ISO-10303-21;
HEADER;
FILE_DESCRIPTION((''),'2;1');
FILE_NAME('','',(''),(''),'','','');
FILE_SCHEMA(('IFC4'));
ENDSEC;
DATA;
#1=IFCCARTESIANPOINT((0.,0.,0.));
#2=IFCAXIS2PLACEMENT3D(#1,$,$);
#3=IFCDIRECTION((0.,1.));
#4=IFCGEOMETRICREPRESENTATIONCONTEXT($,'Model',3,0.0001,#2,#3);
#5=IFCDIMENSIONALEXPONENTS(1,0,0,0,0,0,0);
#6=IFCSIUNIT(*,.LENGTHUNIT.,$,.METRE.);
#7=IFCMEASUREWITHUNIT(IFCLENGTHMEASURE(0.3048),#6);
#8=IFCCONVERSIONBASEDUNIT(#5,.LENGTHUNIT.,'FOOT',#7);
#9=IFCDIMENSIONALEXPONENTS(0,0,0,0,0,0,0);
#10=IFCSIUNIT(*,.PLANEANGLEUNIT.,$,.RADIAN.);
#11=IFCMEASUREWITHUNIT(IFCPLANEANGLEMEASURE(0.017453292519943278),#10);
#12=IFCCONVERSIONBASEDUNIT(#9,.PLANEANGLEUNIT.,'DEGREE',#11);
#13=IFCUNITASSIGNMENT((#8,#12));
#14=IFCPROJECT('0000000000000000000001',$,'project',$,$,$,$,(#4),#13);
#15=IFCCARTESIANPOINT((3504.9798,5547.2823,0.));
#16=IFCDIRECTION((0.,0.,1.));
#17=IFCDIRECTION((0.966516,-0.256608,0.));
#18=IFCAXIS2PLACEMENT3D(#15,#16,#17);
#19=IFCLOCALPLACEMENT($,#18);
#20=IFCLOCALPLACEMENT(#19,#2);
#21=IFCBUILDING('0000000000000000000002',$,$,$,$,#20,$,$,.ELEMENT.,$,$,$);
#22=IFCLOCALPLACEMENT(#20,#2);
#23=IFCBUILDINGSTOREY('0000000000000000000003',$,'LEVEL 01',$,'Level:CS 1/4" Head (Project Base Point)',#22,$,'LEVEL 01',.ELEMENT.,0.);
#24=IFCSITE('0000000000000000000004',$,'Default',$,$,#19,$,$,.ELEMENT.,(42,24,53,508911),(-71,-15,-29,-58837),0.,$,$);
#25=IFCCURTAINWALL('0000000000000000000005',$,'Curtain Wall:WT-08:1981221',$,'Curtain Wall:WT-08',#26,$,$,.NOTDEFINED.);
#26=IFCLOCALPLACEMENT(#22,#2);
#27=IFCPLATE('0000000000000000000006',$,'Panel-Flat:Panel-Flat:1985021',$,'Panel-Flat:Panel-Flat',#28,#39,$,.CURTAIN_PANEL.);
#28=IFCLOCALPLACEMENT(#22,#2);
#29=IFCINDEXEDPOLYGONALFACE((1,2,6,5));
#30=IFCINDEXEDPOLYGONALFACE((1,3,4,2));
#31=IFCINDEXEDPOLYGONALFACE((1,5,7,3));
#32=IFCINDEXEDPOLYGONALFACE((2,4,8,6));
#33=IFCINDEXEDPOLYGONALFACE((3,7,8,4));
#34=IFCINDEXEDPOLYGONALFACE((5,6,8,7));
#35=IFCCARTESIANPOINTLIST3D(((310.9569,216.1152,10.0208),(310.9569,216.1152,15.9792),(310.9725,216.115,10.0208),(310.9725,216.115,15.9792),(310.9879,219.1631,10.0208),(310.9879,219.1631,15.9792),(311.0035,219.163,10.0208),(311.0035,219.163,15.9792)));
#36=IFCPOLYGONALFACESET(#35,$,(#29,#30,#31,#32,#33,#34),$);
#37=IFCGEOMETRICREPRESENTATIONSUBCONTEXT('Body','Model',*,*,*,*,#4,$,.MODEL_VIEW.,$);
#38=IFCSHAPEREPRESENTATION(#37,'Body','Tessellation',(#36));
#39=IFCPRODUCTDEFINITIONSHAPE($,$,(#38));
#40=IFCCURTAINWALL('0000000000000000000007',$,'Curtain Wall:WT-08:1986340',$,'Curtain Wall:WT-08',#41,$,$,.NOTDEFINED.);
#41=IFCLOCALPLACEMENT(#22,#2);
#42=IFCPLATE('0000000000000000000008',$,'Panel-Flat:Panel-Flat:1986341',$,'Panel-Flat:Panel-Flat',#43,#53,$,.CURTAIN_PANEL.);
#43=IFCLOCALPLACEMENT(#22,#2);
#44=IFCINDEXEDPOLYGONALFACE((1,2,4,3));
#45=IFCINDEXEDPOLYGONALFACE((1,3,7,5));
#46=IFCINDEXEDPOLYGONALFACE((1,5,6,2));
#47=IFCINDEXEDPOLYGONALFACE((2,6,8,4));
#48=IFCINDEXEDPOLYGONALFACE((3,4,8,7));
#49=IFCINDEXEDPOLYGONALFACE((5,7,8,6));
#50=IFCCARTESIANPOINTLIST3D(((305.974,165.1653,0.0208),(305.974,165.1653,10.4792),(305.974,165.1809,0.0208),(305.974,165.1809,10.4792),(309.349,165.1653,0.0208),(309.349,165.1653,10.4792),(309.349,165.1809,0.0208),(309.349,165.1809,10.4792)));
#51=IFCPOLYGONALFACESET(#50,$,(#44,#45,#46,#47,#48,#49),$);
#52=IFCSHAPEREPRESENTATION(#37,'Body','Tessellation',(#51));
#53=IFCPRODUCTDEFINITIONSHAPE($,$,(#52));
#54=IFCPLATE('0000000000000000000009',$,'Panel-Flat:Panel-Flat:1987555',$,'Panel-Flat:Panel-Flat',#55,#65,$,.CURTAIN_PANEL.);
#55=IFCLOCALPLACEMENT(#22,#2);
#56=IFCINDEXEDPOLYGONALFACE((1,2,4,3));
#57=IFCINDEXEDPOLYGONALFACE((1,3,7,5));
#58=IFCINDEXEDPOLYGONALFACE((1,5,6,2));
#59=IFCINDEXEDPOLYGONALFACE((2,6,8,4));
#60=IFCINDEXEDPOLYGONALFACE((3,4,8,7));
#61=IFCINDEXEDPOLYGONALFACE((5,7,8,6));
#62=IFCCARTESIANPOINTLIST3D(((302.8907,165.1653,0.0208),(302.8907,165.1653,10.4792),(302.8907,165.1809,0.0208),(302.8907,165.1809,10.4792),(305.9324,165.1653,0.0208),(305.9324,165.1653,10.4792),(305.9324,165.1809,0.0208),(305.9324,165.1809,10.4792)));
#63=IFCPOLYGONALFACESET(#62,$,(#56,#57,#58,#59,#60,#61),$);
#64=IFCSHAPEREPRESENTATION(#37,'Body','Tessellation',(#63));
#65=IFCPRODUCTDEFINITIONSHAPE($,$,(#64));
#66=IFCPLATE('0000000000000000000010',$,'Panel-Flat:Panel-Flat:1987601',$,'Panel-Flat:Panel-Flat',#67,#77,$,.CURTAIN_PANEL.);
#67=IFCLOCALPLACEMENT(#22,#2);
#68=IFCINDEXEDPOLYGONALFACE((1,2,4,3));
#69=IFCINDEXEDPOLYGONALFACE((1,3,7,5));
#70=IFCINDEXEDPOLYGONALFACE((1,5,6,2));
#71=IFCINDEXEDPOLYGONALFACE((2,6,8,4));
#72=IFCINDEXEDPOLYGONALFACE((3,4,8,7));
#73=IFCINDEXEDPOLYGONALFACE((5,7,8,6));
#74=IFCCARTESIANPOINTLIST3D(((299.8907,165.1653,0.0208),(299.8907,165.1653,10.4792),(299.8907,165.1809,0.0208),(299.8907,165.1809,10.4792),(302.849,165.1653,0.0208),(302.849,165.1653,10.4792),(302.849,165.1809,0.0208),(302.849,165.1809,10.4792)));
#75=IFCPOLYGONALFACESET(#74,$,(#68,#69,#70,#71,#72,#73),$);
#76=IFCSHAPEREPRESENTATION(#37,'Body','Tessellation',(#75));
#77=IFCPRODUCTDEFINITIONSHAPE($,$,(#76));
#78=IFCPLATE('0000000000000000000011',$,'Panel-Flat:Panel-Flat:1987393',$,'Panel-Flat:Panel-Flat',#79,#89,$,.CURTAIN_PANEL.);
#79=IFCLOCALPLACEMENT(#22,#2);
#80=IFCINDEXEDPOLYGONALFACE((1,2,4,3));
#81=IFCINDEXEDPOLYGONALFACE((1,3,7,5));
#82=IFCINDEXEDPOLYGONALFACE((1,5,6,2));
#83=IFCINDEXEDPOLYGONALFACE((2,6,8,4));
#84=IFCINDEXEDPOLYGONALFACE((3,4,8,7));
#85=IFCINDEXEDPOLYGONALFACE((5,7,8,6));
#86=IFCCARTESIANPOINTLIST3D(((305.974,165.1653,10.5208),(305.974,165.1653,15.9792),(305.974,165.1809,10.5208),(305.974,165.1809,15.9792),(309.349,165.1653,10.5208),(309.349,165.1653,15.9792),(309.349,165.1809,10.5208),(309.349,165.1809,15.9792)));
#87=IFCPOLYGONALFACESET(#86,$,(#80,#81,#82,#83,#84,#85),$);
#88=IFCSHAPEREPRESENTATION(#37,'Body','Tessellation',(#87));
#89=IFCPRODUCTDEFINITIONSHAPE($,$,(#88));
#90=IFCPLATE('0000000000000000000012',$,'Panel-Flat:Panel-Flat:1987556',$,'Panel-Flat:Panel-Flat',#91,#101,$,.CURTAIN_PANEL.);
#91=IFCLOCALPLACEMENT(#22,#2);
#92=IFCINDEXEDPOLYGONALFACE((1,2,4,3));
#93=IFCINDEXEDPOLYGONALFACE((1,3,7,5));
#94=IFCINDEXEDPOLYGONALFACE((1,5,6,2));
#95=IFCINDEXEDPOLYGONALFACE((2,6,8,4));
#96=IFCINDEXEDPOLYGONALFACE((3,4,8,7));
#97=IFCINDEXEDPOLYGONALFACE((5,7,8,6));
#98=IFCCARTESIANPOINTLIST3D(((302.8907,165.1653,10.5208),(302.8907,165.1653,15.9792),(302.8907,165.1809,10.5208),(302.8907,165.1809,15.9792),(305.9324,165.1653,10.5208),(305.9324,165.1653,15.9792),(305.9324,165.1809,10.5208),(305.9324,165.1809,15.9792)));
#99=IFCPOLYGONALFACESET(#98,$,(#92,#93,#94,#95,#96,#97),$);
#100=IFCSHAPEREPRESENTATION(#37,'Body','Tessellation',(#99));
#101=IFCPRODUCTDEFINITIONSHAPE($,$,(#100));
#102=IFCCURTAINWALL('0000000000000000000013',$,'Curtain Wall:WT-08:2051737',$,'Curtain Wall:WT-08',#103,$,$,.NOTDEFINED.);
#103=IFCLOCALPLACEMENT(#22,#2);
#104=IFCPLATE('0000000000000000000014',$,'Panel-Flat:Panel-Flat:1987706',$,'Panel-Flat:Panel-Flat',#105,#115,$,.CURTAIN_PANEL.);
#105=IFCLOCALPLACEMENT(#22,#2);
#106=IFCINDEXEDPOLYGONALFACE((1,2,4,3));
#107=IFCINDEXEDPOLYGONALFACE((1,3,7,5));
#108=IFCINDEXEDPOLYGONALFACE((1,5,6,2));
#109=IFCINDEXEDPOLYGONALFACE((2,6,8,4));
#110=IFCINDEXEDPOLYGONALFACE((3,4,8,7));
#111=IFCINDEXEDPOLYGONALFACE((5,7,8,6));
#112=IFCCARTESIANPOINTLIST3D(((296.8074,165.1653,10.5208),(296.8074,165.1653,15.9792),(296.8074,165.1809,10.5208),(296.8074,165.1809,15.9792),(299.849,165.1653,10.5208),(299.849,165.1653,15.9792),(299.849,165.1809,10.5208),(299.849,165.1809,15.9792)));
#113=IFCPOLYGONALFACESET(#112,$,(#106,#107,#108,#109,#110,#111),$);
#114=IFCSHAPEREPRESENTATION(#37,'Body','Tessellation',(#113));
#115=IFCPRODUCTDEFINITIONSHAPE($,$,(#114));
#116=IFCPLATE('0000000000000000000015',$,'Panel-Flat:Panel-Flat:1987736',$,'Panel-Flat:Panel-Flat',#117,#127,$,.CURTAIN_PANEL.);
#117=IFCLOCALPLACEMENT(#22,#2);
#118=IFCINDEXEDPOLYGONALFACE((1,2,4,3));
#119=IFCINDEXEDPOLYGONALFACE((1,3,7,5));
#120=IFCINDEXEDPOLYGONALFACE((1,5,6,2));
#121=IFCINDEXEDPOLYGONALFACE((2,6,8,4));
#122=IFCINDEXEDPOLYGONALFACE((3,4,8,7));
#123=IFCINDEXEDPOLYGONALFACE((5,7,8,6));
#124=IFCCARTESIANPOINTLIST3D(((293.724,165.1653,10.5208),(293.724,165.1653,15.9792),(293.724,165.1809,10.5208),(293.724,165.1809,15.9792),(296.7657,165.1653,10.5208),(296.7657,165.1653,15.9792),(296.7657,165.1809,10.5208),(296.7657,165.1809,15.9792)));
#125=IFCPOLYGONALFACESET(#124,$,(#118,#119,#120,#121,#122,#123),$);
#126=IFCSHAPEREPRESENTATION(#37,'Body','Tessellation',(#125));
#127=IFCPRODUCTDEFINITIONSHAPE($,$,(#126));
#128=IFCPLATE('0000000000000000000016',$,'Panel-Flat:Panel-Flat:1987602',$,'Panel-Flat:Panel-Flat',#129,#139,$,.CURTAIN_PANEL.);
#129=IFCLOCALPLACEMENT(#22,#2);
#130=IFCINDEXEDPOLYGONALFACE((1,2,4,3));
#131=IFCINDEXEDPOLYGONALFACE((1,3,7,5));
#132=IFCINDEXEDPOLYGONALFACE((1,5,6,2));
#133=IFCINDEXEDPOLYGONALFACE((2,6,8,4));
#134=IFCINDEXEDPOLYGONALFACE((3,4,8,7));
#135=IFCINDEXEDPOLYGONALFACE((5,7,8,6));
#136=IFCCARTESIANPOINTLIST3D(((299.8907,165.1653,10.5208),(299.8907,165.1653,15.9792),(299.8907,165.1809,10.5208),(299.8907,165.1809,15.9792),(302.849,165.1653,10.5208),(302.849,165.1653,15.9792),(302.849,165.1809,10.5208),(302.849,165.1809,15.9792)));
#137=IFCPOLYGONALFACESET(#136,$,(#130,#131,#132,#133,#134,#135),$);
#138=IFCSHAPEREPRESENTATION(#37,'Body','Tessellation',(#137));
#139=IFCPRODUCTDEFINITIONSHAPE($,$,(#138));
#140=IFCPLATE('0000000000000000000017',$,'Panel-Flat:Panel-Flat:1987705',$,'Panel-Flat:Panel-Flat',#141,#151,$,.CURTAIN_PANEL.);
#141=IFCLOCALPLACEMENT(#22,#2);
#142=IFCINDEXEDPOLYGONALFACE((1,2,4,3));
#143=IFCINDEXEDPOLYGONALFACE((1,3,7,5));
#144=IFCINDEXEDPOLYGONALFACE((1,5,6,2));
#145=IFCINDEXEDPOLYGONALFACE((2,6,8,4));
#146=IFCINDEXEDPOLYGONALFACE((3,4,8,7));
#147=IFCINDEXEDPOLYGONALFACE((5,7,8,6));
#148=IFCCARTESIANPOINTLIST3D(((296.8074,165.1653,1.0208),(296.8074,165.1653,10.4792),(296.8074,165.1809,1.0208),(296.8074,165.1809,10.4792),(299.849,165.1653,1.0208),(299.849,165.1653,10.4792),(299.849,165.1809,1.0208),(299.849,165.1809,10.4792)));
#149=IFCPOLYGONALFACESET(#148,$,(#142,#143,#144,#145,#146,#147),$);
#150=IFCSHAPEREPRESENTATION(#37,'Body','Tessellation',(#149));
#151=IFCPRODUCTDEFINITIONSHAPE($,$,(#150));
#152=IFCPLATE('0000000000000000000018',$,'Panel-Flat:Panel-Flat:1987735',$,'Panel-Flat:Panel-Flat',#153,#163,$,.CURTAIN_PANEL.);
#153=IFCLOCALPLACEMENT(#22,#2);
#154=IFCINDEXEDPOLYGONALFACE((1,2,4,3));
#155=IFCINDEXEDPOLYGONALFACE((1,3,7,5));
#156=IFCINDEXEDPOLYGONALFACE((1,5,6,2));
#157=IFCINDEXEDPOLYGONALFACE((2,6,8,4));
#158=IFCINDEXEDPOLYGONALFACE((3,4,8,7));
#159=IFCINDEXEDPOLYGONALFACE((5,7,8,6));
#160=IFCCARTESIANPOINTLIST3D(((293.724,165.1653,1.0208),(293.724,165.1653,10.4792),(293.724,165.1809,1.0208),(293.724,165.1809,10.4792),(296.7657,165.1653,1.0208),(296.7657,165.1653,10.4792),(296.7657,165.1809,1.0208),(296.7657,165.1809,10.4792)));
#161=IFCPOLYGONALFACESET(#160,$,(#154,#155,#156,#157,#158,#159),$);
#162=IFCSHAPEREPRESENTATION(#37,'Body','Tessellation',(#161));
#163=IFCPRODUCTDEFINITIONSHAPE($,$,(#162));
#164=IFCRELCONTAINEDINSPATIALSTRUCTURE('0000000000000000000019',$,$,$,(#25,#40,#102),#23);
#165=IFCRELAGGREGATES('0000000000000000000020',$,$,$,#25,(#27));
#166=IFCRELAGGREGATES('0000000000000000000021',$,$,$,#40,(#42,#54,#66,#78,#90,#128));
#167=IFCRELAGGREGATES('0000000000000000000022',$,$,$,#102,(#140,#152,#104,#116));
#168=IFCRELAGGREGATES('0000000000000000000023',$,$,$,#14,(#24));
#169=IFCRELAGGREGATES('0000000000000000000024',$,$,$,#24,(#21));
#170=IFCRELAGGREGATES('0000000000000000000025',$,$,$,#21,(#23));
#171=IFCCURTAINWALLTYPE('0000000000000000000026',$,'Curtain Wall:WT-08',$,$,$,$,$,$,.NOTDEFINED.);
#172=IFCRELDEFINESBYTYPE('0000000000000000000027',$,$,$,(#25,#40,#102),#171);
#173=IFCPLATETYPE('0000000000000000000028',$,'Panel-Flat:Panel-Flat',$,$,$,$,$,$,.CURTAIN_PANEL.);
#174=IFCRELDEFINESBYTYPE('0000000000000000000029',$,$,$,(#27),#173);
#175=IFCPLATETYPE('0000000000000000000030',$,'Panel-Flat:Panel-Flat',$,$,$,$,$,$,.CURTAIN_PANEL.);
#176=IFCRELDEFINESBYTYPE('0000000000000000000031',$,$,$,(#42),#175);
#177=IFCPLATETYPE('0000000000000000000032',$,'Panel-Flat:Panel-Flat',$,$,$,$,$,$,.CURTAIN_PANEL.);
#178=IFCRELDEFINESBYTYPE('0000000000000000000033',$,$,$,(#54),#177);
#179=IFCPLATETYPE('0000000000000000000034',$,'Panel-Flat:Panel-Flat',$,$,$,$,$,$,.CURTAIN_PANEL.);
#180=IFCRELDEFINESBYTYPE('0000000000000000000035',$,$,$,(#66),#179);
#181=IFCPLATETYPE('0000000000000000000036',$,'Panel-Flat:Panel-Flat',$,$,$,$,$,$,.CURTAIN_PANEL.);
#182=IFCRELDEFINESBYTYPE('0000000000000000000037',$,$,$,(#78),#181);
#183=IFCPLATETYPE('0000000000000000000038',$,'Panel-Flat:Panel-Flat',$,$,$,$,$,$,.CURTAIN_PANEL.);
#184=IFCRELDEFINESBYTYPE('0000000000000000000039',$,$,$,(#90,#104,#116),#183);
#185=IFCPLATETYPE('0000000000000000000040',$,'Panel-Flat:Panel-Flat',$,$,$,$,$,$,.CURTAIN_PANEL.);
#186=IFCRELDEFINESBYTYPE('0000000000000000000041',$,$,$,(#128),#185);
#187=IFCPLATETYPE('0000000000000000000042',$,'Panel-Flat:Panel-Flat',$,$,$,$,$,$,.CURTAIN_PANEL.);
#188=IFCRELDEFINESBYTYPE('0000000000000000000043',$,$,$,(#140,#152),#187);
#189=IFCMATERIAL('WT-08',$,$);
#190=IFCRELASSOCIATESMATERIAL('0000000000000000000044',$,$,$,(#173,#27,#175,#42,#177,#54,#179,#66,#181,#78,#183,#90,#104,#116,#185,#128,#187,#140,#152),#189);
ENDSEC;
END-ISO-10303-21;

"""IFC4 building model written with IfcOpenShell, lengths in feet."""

from ifc_helpers import new_model, entity, si_unit, converted_unit, direction, frame, origin, place, context, subcontext, project, spatial, indexed_curve, outline, extrude, source, transform, mapped, material, type_object, type_shapes, element, aggregate, save


model = new_model("IFC4")

# Units and contexts
model_context = context("Model", 3, precision=0.0001, world=origin(), true_north=direction((0.0, 1.0)))
body_context = subcontext(model_context, "Body", "Model", "MODEL_VIEW")
ifc_project = project(units=[converted_unit("LENGTHUNIT", "FOOT", entity("IfcLengthMeasure", 0.3048), si_unit("LENGTHUNIT", "METRE"), dimensions=[1, 0, 0, 0, 0, 0, 0]), converted_unit("PLANEANGLEUNIT", "DEGREE", entity("IfcPlaneAngleMeasure", 0.017453292519943278), si_unit("PLANEANGLEUNIT", "RADIAN"), dimensions=[0, 0, 0, 0, 0, 0, 0])], contexts=[model_context])

# Site, building, storey
site_placement = place(None, frame((3504.9798, 5547.2823, 0.0), z_axis=(0.0, 0.0, 1.0), x_axis=(0.966516, -0.256608, 0.0)))
site = spatial("IfcSite", under=ifc_project, at=site_placement, Name="Default", CompositionType="ELEMENT", RefLatitude=(42, 24, 53, 508911), RefLongitude=(-71, -15, -29, -58837), RefElevation=0.0)
building_placement = place(site_placement, origin())
building = spatial("IfcBuilding", under=site, at=building_placement, CompositionType="ELEMENT")
storey_placement = place(building_placement, origin())
storey = spatial("IfcBuildingStorey", under=building, at=storey_placement, Name="LEVEL 01", ObjectType="Level:CS 1/4\" Head (Project Base Point)", LongName="LEVEL 01", CompositionType="ELEMENT", Elevation=0.0)

# Curtain walls, plates
curtain_wall_type_1 = type_object("IfcCurtainWallType", Name="Curtain Wall:WT-08", PredefinedType="NOTDEFINED")
curtain_wall_1_placement = place(storey_placement, origin())
curtain_wall_1 = element("IfcCurtainWall", 1, at=curtain_wall_1_placement, inside=storey, type_object=curtain_wall_type_1, Name="Curtain Wall:WT-08:1981221", ObjectType="Curtain Wall:WT-08", PredefinedType="NOTDEFINED")
ifc_material_1 = material(Name="WT-08")
plate_type_1 = type_object("IfcPlateType", Name="Panel-Flat:Panel-Flat", PredefinedType="CURTAIN_PANEL", material=ifc_material_1)
shared_shape_1 = source(origin(), body_context, "Body", "SweptSolid", [
    extrude(outline(indexed_curve([(-0.0078, -1.5241), (0.0078, -1.5241), (0.0078, 1.5241), (-0.0078, 1.5241), (-0.0078, -1.5241)], self_intersect=False)), frame((0.0, -0.0078, 0.0208), z_axis=(0.0, 0.0, 1.0), x_axis=(0.0, -1.0, 0.0)), (0.0, 0.0, 1.0), 5.9583),
])
type_shapes(plate_type_1, [shared_shape_1])
plate_1_placement = place(curtain_wall_1_placement, frame((310.988, 217.639, 10.0), z_axis=(0.0, 0.0, 1.0), x_axis=(-0.010193, -0.999948, 0.0)))
plate_1 = element("IfcPlate", 2, at=plate_1_placement, type_object=plate_type_1, material=ifc_material_1, Name="Panel-Flat:Panel-Flat:1985021", ObjectType="Panel-Flat:Panel-Flat", PredefinedType="CURTAIN_PANEL", context=body_context, shape_type="MappedRepresentation", body=[
    mapped(shared_shape_1, transform((0.0, 0.0, 0.0), scale=1.0)),
])
aggregate(curtain_wall_1, [plate_1])
curtain_wall_2_placement = place(storey_placement, origin())
curtain_wall_2 = element("IfcCurtainWall", 3, at=curtain_wall_2_placement, inside=storey, type_object=curtain_wall_type_1, Name="Curtain Wall:WT-08:1986340", ObjectType="Curtain Wall:WT-08", PredefinedType="NOTDEFINED")
plate_type_2 = type_object("IfcPlateType", Name="Panel-Flat:Panel-Flat", PredefinedType="CURTAIN_PANEL", material=ifc_material_1)
shared_shape_2 = source(origin(), body_context, "Body", "SweptSolid", [
    extrude(outline(indexed_curve([(-0.0078, -1.6875), (0.0078, -1.6875), (0.0078, 1.6875), (-0.0078, 1.6875), (-0.0078, -1.6875)], self_intersect=False)), frame((0.0, -0.0078, 0.0208), z_axis=(0.0, 0.0, 1.0), x_axis=(0.0, -1.0, 0.0)), (0.0, 0.0, 1.0), 10.4583),
])
type_shapes(plate_type_2, [shared_shape_2])
plate_2_placement = place(curtain_wall_2_placement, frame((307.6615, 165.1653, 0.0), z_axis=(0.0, 0.0, 1.0), x_axis=(-1.0, 0.0, 0.0)))
plate_2 = element("IfcPlate", 4, at=plate_2_placement, type_object=plate_type_2, material=ifc_material_1, Name="Panel-Flat:Panel-Flat:1986341", ObjectType="Panel-Flat:Panel-Flat", PredefinedType="CURTAIN_PANEL", context=body_context, shape_type="MappedRepresentation", body=[
    mapped(shared_shape_2, transform((0.0, 0.0, 0.0), scale=1.0)),
])
plate_type_3 = type_object("IfcPlateType", Name="Panel-Flat:Panel-Flat", PredefinedType="CURTAIN_PANEL", material=ifc_material_1)
shared_shape_3 = source(origin(), body_context, "Body", "SweptSolid", [
    extrude(outline(indexed_curve([(-0.0078, -1.5208), (0.0078, -1.5208), (0.0078, 1.5208), (-0.0078, 1.5208), (-0.0078, -1.5208)], self_intersect=False)), frame((0.0, -0.0078, 0.0208), z_axis=(0.0, 0.0, 1.0), x_axis=(0.0, -1.0, 0.0)), (0.0, 0.0, 1.0), 10.4583),
])
type_shapes(plate_type_3, [shared_shape_3])
plate_3_placement = place(curtain_wall_2_placement, frame((304.4115, 165.1653, 0.0), z_axis=(0.0, 0.0, 1.0), x_axis=(-1.0, 0.0, 0.0)))
plate_3 = element("IfcPlate", 5, at=plate_3_placement, type_object=plate_type_3, material=ifc_material_1, Name="Panel-Flat:Panel-Flat:1987555", ObjectType="Panel-Flat:Panel-Flat", PredefinedType="CURTAIN_PANEL", context=body_context, shape_type="MappedRepresentation", body=[
    mapped(shared_shape_3, transform((0.0, 0.0, 0.0), scale=1.0)),
])
plate_type_4 = type_object("IfcPlateType", Name="Panel-Flat:Panel-Flat", PredefinedType="CURTAIN_PANEL", material=ifc_material_1)
shared_shape_4 = source(origin(), body_context, "Body", "SweptSolid", [
    extrude(outline(indexed_curve([(-0.0078, -1.4792), (0.0078, -1.4792), (0.0078, 1.4792), (-0.0078, 1.4792), (-0.0078, -1.4792)], self_intersect=False)), frame((0.0, -0.0078, 0.0208), z_axis=(0.0, 0.0, 1.0), x_axis=(0.0, -1.0, 0.0)), (0.0, 0.0, 1.0), 10.4583),
])
type_shapes(plate_type_4, [shared_shape_4])
plate_4_placement = place(curtain_wall_2_placement, frame((301.3699, 165.1653, 0.0), z_axis=(0.0, 0.0, 1.0), x_axis=(-1.0, 0.0, 0.0)))
plate_4 = element("IfcPlate", 6, at=plate_4_placement, type_object=plate_type_4, material=ifc_material_1, Name="Panel-Flat:Panel-Flat:1987601", ObjectType="Panel-Flat:Panel-Flat", PredefinedType="CURTAIN_PANEL", context=body_context, shape_type="MappedRepresentation", body=[
    mapped(shared_shape_4, transform((0.0, 0.0, 0.0), scale=1.0)),
])
plate_type_5 = type_object("IfcPlateType", Name="Panel-Flat:Panel-Flat", PredefinedType="CURTAIN_PANEL", material=ifc_material_1)
shared_shape_5 = source(origin(), body_context, "Body", "SweptSolid", [
    extrude(outline(indexed_curve([(-0.0078, -1.6875), (0.0078, -1.6875), (0.0078, 1.6875), (-0.0078, 1.6875), (-0.0078, -1.6875)], self_intersect=False)), frame((0.0, -0.0078, 0.0208), z_axis=(0.0, 0.0, 1.0), x_axis=(0.0, -1.0, 0.0)), (0.0, 0.0, 1.0), 5.4583),
])
type_shapes(plate_type_5, [shared_shape_5])
plate_5_placement = place(curtain_wall_2_placement, frame((307.6615, 165.1653, 10.5), z_axis=(0.0, 0.0, 1.0), x_axis=(-1.0, 0.0, 0.0)))
plate_5 = element("IfcPlate", 7, at=plate_5_placement, type_object=plate_type_5, material=ifc_material_1, Name="Panel-Flat:Panel-Flat:1987393", ObjectType="Panel-Flat:Panel-Flat", PredefinedType="CURTAIN_PANEL", context=body_context, shape_type="MappedRepresentation", body=[
    mapped(shared_shape_5, transform((0.0, 0.0, 0.0), scale=1.0)),
])
plate_type_6 = type_object("IfcPlateType", Name="Panel-Flat:Panel-Flat", PredefinedType="CURTAIN_PANEL", material=ifc_material_1)
shared_shape_6 = source(origin(), body_context, "Body", "SweptSolid", [
    extrude(outline(indexed_curve([(-0.0078, -1.5208), (0.0078, -1.5208), (0.0078, 1.5208), (-0.0078, 1.5208), (-0.0078, -1.5208)], self_intersect=False)), frame((0.0, -0.0078, 0.0208), z_axis=(0.0, 0.0, 1.0), x_axis=(0.0, -1.0, 0.0)), (0.0, 0.0, 1.0), 5.4583),
])
type_shapes(plate_type_6, [shared_shape_6])
plate_6_placement = place(curtain_wall_2_placement, frame((304.4115, 165.1653, 10.5), z_axis=(0.0, 0.0, 1.0), x_axis=(-1.0, 0.0, 0.0)))
plate_6 = element("IfcPlate", 8, at=plate_6_placement, type_object=plate_type_6, material=ifc_material_1, Name="Panel-Flat:Panel-Flat:1987556", ObjectType="Panel-Flat:Panel-Flat", PredefinedType="CURTAIN_PANEL", context=body_context, shape_type="MappedRepresentation", body=[
    mapped(shared_shape_6, transform((0.0, 0.0, 0.0), scale=1.0)),
])
curtain_wall_3_placement = place(storey_placement, origin())
curtain_wall_3 = element("IfcCurtainWall", 9, at=curtain_wall_3_placement, inside=storey, type_object=curtain_wall_type_1, Name="Curtain Wall:WT-08:2051737", ObjectType="Curtain Wall:WT-08", PredefinedType="NOTDEFINED")
plate_7_placement = place(curtain_wall_3_placement, frame((298.3282, 165.1653, 10.5), z_axis=(0.0, 0.0, 1.0), x_axis=(-1.0, 0.0, 0.0)))
plate_7 = element("IfcPlate", 10, at=plate_7_placement, type_object=plate_type_6, material=ifc_material_1, Name="Panel-Flat:Panel-Flat:1987706", ObjectType="Panel-Flat:Panel-Flat", PredefinedType="CURTAIN_PANEL", context=body_context, shape_type="MappedRepresentation", body=[
    mapped(shared_shape_6, transform((0.0, 0.0, 0.0), scale=1.0)),
])
plate_8_placement = place(curtain_wall_3_placement, frame((295.2449, 165.1653, 10.5), z_axis=(0.0, 0.0, 1.0), x_axis=(-1.0, 0.0, 0.0)))
plate_8 = element("IfcPlate", 11, at=plate_8_placement, type_object=plate_type_6, material=ifc_material_1, Name="Panel-Flat:Panel-Flat:1987736", ObjectType="Panel-Flat:Panel-Flat", PredefinedType="CURTAIN_PANEL", context=body_context, shape_type="MappedRepresentation", body=[
    mapped(shared_shape_6, transform((0.0, 0.0, 0.0), scale=1.0)),
])

# Plate
plate_type_7 = type_object("IfcPlateType", Name="Panel-Flat:Panel-Flat", PredefinedType="CURTAIN_PANEL", material=ifc_material_1)
shared_shape_7 = source(origin(), body_context, "Body", "SweptSolid", [
    extrude(outline(indexed_curve([(-0.0078, -1.4792), (0.0078, -1.4792), (0.0078, 1.4792), (-0.0078, 1.4792), (-0.0078, -1.4792)], self_intersect=False)), frame((0.0, -0.0078, 0.0208), z_axis=(0.0, 0.0, 1.0), x_axis=(0.0, -1.0, 0.0)), (0.0, 0.0, 1.0), 5.4583),
])
type_shapes(plate_type_7, [shared_shape_7])
plate_9_placement = place(curtain_wall_2_placement, frame((301.3699, 165.1653, 10.5), z_axis=(0.0, 0.0, 1.0), x_axis=(-1.0, 0.0, 0.0)))
plate_9 = element("IfcPlate", 12, at=plate_9_placement, type_object=plate_type_7, material=ifc_material_1, Name="Panel-Flat:Panel-Flat:1987602", ObjectType="Panel-Flat:Panel-Flat", PredefinedType="CURTAIN_PANEL", context=body_context, shape_type="MappedRepresentation", body=[
    mapped(shared_shape_7, transform((0.0, 0.0, 0.0), scale=1.0)),
])
aggregate(curtain_wall_2, [plate_2, plate_3, plate_4, plate_5, plate_6, plate_9])

# Plates
plate_type_8 = type_object("IfcPlateType", Name="Panel-Flat:Panel-Flat", PredefinedType="CURTAIN_PANEL", material=ifc_material_1)
shared_shape_8 = source(origin(), body_context, "Body", "SweptSolid", [
    extrude(outline(indexed_curve([(-0.0078, -1.5208), (0.0078, -1.5208), (0.0078, 1.5208), (-0.0078, 1.5208), (-0.0078, -1.5208)], self_intersect=False)), frame((0.0, -0.0078, 0.0208), z_axis=(0.0, 0.0, 1.0), x_axis=(0.0, -1.0, 0.0)), (0.0, 0.0, 1.0), 9.4583),
])
type_shapes(plate_type_8, [shared_shape_8])
plate_10_placement = place(curtain_wall_3_placement, frame((298.3282, 165.1653, 1.0), z_axis=(0.0, 0.0, 1.0), x_axis=(-1.0, 0.0, 0.0)))
plate_10 = element("IfcPlate", 13, at=plate_10_placement, type_object=plate_type_8, material=ifc_material_1, Name="Panel-Flat:Panel-Flat:1987705", ObjectType="Panel-Flat:Panel-Flat", PredefinedType="CURTAIN_PANEL", context=body_context, shape_type="MappedRepresentation", body=[
    mapped(shared_shape_8, transform((0.0, 0.0, 0.0), scale=1.0)),
])
plate_11_placement = place(curtain_wall_3_placement, frame((295.2449, 165.1653, 1.0), z_axis=(0.0, 0.0, 1.0), x_axis=(-1.0, 0.0, 0.0)))
plate_11 = element("IfcPlate", 14, at=plate_11_placement, type_object=plate_type_8, material=ifc_material_1, Name="Panel-Flat:Panel-Flat:1987735", ObjectType="Panel-Flat:Panel-Flat", PredefinedType="CURTAIN_PANEL", context=body_context, shape_type="MappedRepresentation", body=[
    mapped(shared_shape_8, transform((0.0, 0.0, 0.0), scale=1.0)),
])
aggregate(curtain_wall_3, [plate_10, plate_11, plate_7, plate_8])

save(model, "model.ifc")
